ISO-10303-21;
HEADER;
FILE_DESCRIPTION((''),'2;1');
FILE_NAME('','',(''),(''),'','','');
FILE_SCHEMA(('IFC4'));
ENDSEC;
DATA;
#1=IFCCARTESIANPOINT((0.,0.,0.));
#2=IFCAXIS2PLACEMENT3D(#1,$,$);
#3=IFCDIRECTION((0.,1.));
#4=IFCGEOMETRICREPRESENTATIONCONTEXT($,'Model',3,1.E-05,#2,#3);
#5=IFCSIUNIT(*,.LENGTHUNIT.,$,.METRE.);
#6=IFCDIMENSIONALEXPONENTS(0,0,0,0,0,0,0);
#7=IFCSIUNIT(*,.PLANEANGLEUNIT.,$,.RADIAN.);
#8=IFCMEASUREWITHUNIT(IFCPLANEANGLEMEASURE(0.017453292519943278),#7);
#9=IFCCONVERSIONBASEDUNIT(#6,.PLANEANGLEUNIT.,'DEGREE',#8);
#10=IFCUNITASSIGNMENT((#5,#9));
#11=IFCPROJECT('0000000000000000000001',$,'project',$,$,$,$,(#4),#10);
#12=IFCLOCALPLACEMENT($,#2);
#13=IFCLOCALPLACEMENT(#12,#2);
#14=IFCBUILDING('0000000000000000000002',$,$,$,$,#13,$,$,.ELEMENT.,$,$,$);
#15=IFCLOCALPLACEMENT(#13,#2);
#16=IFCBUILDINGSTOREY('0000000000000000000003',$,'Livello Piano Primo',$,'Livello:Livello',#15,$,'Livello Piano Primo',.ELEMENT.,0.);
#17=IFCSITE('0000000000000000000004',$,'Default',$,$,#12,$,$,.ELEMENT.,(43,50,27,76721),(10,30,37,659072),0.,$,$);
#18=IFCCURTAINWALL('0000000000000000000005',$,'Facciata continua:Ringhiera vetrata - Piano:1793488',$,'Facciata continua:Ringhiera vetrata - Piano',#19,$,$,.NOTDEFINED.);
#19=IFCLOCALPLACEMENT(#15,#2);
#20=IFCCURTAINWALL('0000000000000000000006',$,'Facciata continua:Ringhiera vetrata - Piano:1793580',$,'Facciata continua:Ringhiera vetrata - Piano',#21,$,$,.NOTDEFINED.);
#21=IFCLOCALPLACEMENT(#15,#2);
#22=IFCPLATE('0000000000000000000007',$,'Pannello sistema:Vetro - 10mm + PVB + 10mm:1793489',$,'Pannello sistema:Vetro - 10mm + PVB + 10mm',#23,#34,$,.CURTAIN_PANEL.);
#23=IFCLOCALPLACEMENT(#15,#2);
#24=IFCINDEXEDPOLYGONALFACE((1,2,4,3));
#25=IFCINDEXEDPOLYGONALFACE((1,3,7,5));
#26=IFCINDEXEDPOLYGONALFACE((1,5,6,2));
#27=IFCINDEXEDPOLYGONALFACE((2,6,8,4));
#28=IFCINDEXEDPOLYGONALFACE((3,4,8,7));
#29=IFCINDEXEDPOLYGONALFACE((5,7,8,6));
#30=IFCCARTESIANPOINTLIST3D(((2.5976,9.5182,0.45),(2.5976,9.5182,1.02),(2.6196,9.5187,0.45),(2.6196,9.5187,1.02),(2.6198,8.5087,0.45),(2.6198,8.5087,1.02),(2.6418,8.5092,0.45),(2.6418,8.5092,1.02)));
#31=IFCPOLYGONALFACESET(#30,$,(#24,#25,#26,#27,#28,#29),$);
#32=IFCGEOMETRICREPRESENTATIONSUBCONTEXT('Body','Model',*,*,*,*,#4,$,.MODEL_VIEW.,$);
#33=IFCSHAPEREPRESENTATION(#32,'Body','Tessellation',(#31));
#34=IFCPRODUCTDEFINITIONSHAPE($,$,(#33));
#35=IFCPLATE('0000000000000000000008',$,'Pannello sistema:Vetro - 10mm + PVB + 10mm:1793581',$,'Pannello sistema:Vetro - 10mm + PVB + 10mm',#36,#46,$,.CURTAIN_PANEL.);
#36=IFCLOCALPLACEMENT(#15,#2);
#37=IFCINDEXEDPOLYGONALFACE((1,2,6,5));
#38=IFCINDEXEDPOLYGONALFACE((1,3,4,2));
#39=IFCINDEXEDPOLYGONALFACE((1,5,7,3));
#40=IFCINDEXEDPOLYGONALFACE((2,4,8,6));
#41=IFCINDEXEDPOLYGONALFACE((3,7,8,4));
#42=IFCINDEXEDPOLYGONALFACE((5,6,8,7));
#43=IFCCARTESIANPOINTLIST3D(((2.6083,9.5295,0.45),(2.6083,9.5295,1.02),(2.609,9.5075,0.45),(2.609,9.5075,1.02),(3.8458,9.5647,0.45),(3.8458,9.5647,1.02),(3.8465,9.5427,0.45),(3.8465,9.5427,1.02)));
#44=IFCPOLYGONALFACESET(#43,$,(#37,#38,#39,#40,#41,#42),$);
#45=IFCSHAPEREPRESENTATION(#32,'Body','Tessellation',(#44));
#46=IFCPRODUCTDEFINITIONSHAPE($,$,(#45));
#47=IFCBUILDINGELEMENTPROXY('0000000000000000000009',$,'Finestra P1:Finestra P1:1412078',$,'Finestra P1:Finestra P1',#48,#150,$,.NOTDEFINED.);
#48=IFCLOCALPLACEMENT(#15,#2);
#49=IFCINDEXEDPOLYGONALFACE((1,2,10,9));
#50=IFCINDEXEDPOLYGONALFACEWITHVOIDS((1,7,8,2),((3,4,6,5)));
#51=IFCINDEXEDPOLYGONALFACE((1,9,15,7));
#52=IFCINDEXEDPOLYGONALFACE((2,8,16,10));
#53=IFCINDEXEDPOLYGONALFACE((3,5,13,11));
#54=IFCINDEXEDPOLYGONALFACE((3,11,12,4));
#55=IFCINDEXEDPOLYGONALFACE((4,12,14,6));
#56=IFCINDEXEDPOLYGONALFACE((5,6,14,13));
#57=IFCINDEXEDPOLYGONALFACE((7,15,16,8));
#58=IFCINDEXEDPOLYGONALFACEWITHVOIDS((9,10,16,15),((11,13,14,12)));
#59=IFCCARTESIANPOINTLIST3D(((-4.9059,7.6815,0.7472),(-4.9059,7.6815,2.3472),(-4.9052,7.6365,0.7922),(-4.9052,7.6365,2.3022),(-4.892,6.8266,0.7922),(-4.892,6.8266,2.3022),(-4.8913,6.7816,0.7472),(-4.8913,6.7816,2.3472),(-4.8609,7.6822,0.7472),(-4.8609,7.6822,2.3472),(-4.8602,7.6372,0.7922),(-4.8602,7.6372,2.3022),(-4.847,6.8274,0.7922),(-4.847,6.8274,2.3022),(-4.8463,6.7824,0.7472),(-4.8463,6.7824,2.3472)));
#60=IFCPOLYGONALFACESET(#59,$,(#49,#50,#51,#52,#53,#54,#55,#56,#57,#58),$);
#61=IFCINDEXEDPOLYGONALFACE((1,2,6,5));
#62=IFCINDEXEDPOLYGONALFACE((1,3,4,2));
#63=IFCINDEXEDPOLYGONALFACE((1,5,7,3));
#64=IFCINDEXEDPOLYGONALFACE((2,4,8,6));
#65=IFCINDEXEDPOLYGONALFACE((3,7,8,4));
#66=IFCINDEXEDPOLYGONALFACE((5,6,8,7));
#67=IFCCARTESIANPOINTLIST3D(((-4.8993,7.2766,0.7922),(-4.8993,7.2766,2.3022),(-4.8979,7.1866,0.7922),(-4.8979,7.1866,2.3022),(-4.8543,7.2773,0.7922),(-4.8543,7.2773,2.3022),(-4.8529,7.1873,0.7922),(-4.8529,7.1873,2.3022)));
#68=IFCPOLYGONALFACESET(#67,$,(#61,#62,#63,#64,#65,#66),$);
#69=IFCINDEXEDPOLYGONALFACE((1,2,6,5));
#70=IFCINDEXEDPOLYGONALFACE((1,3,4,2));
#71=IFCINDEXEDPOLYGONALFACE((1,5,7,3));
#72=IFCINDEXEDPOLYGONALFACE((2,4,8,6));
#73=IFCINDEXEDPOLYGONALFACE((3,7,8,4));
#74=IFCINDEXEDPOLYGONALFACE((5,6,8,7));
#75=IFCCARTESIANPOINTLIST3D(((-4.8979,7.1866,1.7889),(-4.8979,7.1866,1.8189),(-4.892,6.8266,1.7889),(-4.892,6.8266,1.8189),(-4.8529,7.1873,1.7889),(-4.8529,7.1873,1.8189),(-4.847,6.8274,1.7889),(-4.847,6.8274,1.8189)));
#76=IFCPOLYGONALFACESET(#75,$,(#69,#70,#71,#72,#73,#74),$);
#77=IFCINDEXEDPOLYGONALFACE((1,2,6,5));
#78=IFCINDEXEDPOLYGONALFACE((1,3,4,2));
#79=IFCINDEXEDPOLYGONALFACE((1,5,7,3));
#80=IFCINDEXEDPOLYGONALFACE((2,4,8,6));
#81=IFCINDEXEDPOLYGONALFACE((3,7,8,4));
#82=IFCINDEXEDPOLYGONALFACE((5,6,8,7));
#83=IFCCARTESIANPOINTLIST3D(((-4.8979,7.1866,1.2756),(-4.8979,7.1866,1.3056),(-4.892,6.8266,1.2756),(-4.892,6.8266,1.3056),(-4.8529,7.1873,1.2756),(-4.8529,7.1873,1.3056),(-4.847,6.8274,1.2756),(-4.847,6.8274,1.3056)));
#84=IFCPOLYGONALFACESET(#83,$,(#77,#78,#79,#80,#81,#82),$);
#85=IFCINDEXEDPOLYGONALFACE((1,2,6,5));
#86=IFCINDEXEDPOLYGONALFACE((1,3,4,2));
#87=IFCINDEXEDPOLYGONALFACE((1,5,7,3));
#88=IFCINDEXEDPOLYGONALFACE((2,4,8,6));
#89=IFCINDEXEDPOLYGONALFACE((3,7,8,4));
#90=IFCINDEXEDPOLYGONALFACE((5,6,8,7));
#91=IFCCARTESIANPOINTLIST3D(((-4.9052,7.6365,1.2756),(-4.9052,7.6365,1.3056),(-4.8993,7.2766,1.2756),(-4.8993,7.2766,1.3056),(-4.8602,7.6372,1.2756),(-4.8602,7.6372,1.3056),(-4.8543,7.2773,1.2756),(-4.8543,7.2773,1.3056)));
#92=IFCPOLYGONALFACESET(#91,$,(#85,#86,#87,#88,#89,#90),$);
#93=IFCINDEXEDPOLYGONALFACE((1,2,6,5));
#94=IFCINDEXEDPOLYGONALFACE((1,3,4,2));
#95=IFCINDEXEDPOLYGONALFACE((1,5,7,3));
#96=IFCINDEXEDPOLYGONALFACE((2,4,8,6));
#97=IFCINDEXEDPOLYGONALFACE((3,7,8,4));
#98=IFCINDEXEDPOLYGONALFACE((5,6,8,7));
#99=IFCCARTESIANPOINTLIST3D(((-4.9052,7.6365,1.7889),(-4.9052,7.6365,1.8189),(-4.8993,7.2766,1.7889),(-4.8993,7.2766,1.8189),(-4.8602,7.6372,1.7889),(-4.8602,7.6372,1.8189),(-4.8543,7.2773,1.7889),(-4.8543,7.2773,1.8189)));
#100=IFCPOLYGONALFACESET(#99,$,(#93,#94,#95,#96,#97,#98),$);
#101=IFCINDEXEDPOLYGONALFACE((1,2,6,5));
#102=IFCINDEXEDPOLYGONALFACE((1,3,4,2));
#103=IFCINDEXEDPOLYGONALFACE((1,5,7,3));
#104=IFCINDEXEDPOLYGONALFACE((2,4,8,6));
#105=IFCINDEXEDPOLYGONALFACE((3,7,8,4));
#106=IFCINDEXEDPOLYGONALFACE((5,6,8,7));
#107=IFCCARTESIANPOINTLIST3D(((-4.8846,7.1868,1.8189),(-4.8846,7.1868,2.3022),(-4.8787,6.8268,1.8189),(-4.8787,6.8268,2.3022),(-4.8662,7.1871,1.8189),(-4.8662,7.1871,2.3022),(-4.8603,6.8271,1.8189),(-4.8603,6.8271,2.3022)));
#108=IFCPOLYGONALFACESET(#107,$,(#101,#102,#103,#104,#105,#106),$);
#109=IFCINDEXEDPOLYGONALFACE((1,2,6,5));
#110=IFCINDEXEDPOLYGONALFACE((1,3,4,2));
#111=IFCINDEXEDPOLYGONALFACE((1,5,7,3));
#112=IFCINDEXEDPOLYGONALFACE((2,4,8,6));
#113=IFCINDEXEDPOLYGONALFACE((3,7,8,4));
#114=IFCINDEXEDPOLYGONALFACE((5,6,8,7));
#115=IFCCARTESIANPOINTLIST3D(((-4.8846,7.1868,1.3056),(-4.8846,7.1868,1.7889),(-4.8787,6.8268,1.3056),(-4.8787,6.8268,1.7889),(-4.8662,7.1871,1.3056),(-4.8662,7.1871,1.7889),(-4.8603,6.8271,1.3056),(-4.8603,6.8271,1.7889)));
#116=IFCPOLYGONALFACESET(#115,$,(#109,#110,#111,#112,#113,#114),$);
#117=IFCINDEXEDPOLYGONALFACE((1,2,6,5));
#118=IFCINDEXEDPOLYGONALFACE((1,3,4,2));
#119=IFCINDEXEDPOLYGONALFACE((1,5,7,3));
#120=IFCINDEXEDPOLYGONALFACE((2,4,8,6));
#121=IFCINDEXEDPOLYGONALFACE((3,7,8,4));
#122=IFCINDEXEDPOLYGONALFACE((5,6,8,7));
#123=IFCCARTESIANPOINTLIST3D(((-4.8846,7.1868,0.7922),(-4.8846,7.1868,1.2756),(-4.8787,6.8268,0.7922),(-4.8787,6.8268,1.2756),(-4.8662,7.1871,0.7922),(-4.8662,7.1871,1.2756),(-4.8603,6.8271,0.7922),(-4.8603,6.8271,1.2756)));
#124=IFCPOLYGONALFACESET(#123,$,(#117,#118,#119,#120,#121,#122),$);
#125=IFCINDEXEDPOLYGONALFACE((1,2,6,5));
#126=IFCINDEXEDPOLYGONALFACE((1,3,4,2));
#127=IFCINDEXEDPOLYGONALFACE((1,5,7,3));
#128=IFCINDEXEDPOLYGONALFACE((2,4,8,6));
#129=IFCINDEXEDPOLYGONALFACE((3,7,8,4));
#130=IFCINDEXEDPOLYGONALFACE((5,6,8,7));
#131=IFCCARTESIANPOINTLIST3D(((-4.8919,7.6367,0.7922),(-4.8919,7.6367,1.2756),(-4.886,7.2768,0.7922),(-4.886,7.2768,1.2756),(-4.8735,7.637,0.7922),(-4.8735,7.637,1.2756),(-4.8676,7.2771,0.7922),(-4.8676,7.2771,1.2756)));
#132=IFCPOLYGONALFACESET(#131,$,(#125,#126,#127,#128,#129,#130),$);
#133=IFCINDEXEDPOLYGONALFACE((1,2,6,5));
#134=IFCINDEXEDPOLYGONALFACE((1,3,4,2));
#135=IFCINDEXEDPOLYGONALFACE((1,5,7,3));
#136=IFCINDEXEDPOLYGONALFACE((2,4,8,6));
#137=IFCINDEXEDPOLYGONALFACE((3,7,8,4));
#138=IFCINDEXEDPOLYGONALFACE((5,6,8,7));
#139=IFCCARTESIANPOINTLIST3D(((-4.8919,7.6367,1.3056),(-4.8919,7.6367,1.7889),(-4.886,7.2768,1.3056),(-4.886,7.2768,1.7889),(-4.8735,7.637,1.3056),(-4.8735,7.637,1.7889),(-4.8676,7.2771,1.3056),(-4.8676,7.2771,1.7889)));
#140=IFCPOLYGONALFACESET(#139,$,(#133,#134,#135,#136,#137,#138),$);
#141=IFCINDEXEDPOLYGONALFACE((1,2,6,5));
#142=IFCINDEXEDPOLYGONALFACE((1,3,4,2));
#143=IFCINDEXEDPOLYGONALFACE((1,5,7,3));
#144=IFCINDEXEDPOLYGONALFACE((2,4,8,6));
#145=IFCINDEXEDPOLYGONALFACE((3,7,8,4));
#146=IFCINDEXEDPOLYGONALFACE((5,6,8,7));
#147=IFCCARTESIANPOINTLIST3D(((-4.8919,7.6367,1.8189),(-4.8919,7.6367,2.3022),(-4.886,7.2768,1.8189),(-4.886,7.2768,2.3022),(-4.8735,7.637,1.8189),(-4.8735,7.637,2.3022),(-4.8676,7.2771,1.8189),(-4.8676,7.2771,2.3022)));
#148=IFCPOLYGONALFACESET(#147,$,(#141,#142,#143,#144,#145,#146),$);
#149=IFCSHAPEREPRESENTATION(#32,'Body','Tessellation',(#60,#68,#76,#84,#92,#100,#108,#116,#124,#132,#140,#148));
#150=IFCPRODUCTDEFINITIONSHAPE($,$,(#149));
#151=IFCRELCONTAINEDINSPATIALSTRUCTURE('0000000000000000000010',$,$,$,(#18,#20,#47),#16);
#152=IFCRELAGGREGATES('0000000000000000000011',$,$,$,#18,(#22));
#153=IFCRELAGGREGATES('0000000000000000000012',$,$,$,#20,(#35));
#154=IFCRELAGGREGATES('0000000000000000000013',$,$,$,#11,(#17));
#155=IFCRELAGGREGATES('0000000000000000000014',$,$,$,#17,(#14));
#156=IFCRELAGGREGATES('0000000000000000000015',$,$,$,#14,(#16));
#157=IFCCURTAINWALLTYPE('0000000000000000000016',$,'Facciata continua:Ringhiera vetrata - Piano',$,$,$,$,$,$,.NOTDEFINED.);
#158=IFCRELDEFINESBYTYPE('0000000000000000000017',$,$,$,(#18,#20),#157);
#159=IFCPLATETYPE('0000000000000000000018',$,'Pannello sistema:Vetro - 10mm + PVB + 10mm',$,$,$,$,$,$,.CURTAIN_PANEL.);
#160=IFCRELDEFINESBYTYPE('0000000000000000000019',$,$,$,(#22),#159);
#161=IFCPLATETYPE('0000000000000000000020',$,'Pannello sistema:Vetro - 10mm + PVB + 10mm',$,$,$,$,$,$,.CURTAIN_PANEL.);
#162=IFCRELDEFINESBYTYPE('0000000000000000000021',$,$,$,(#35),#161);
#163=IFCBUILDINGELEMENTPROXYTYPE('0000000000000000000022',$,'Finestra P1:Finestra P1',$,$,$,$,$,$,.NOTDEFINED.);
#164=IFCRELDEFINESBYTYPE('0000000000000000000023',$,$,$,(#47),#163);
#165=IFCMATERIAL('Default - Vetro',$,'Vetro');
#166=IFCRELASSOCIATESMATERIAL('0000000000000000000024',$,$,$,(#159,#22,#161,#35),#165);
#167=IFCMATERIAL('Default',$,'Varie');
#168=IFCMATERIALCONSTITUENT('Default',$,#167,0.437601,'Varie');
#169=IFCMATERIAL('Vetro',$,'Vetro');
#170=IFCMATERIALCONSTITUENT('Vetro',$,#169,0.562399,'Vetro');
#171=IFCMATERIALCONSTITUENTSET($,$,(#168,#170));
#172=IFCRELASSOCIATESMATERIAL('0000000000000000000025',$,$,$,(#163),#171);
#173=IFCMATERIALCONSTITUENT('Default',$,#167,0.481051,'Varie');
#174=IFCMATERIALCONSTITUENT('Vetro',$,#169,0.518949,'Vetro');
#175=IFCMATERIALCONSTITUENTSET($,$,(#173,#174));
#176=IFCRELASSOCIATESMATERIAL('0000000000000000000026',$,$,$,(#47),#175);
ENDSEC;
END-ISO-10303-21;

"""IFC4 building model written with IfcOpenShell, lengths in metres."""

from ifc_helpers import new_model, entity, si_unit, converted_unit, direction, frame, origin, place, context, subcontext, project, spatial, indexed_curve, outline, extrude, source, transform, mapped, material, constituent, constituent_set, type_object, type_shapes, element, aggregate, save


model = new_model("IFC4")

# Units and contexts
model_context = context("Model", 3, precision=1e-05, world=origin(), true_north=direction((0.0, 1.0)))
body_context = subcontext(model_context, "Body", "Model", "MODEL_VIEW")
ifc_project = project(units=[si_unit("LENGTHUNIT", "METRE"), converted_unit("PLANEANGLEUNIT", "DEGREE", entity("IfcPlaneAngleMeasure", 0.017453292519943278), si_unit("PLANEANGLEUNIT", "RADIAN"), dimensions=[0, 0, 0, 0, 0, 0, 0])], contexts=[model_context])

# Site, building, storey
site_placement = place(None, origin())
site = spatial("IfcSite", under=ifc_project, at=site_placement, Name="Default", CompositionType="ELEMENT", RefLatitude=(43, 50, 27, 76721), RefLongitude=(10, 30, 37, 659072), RefElevation=0.0)
building_placement = place(site_placement, origin())
building = spatial("IfcBuilding", under=site, at=building_placement, CompositionType="ELEMENT")
storey_placement = place(building_placement, origin())
storey = spatial("IfcBuildingStorey", under=building, at=storey_placement, Name="Livello Piano Primo", ObjectType="Livello:Livello", LongName="Livello Piano Primo", CompositionType="ELEMENT", Elevation=0.0)

# Curtain walls
curtain_wall_type = type_object("IfcCurtainWallType", Name="Facciata continua:Ringhiera vetrata - Piano", PredefinedType="NOTDEFINED")
curtain_wall_1_placement = place(storey_placement, origin())
curtain_wall_1 = element("IfcCurtainWall", 1, at=curtain_wall_1_placement, inside=storey, type_object=curtain_wall_type, Name="Facciata continua:Ringhiera vetrata - Piano:1793488", ObjectType="Facciata continua:Ringhiera vetrata - Piano", PredefinedType="NOTDEFINED")
curtain_wall_2_placement = place(storey_placement, origin())
curtain_wall_2 = element("IfcCurtainWall", 2, at=curtain_wall_2_placement, inside=storey, type_object=curtain_wall_type, Name="Facciata continua:Ringhiera vetrata - Piano:1793580", ObjectType="Facciata continua:Ringhiera vetrata - Piano", PredefinedType="NOTDEFINED")

# Plates
ifc_material_1 = material(Name="Default - Vetro", Category="Vetro")
plate_type_1 = type_object("IfcPlateType", Name="Pannello sistema:Vetro - 10mm + PVB + 10mm", PredefinedType="CURTAIN_PANEL", material=ifc_material_1)
shared_shape_1 = source(origin(), body_context, "Body", "SweptSolid", [
    extrude(outline(indexed_curve([(-0.011, -0.5049), (0.011, -0.5049), (0.011, 0.5049), (-0.011, 0.5049), (-0.011, -0.5049)], self_intersect=False)), frame((0.0, 0.0, 0.0), z_axis=(0.0, 0.0, 1.0), x_axis=(0.0, 1.0, 0.0)), (0.0, 0.0, 1.0), 0.57),
])
type_shapes(plate_type_1, [shared_shape_1])
plate_1_placement = place(curtain_wall_1_placement, frame((2.6197, 9.0137, 0.45), z_axis=(0.0, 0.0, 1.0), x_axis=(-0.021989, 0.999758, 0.0)))
plate_1 = element("IfcPlate", 3, at=plate_1_placement, type_object=plate_type_1, material=ifc_material_1, Name="Pannello sistema:Vetro - 10mm + PVB + 10mm:1793489", ObjectType="Pannello sistema:Vetro - 10mm + PVB + 10mm", PredefinedType="CURTAIN_PANEL", context=body_context, shape_type="MappedRepresentation", body=[
    mapped(shared_shape_1, transform((0.0, 0.0, 0.0), scale=1.0)),
])
aggregate(curtain_wall_1, [plate_1])
plate_type_2 = type_object("IfcPlateType", Name="Pannello sistema:Vetro - 10mm + PVB + 10mm", PredefinedType="CURTAIN_PANEL", material=ifc_material_1)
shared_shape_2 = source(origin(), body_context, "Body", "SweptSolid", [
    extrude(outline(indexed_curve([(-0.011, -0.619), (0.011, -0.619), (0.011, 0.619), (-0.011, 0.619), (-0.011, -0.619)], self_intersect=False)), frame((0.0, 0.0, 0.0), z_axis=(0.0, 0.0, 1.0), x_axis=(0.0, 1.0, 0.0)), (0.0, 0.0, 1.0), 0.57),
])
type_shapes(plate_type_2, [shared_shape_2])
plate_2_placement = place(curtain_wall_2_placement, frame((3.2274, 9.5361, 0.45), z_axis=(0.0, 0.0, 1.0), x_axis=(0.999596, 0.028429, 0.0)))
plate_2 = element("IfcPlate", 4, at=plate_2_placement, type_object=plate_type_2, material=ifc_material_1, Name="Pannello sistema:Vetro - 10mm + PVB + 10mm:1793581", ObjectType="Pannello sistema:Vetro - 10mm + PVB + 10mm", PredefinedType="CURTAIN_PANEL", context=body_context, shape_type="MappedRepresentation", body=[
    mapped(shared_shape_2, transform((0.0, 0.0, 0.0), scale=1.0)),
])
aggregate(curtain_wall_2, [plate_2])

# Building element proxy
ifc_material_2 = material(Name="Default", Category="Varie")
ifc_constituent_1 = constituent(ifc_material_2, Name="Default", Category="Varie", fraction=0.481051)
ifc_material_3 = material(Name="Vetro", Category="Vetro")
ifc_constituent_2 = constituent(ifc_material_3, Name="Vetro", Category="Vetro", fraction=0.518949)
ifc_constituent_set_1 = constituent_set(constituents=[ifc_constituent_1, ifc_constituent_2])
ifc_constituent_3 = constituent(ifc_material_2, Name="Default", Category="Varie", fraction=0.437601)
ifc_constituent_4 = constituent(ifc_material_3, Name="Vetro", Category="Vetro", fraction=0.562399)
ifc_constituent_set_2 = constituent_set(constituents=[ifc_constituent_3, ifc_constituent_4])
building_element_proxy_type_1 = type_object("IfcBuildingElementProxyType", Name="Finestra P1:Finestra P1", PredefinedType="NOTDEFINED", material=ifc_constituent_set_2)
shared_shape_3 = source(origin(), body_context, "Body", "SweptSolid", [
    extrude(outline(indexed_curve([(-0.8, -0.45), (0.8, -0.45), (0.8, 0.45), (-0.8, 0.45), (-0.8, -0.45)], self_intersect=False), holes=[indexed_curve([(0.755, -0.405), (-0.755, -0.405), (-0.755, 0.405), (0.755, 0.405), (0.755, -0.405)], self_intersect=False)]), frame((0.0, -0.0225, 0.8), z_axis=(0.0, 1.0, 0.0), x_axis=(0.0, 0.0, -1.0)), (0.0, 0.0, 1.0), 0.045),
    extrude(outline(indexed_curve([(-0.045, -0.0225), (0.045, -0.0225), (0.045, 0.0225), (-0.045, 0.0225), (-0.045, -0.0225)], self_intersect=False)), frame((0.0, 0.0, 0.045), z_axis=(0.0, 0.0, 1.0), x_axis=(-1.0, 0.0, 0.0)), (0.0, 0.0, 1.0), 1.51),
    extrude(outline(indexed_curve([(-0.18, -0.0225), (0.18, -0.0225), (0.18, 0.0225), (-0.18, 0.0225), (-0.18, -0.0225)], self_intersect=False)), frame((0.225, 0.0, 1.0417)), (0.0, 0.0, 1.0), 0.03),
    extrude(outline(indexed_curve([(-0.18, -0.0225), (0.18, -0.0225), (0.18, 0.0225), (-0.18, 0.0225), (-0.18, -0.0225)], self_intersect=False)), frame((0.225, 0.0, 0.5283)), (0.0, 0.0, 1.0), 0.03),
    extrude(outline(indexed_curve([(-0.18, -0.0225), (0.18, -0.0225), (0.18, 0.0225), (-0.18, 0.0225), (-0.18, -0.0225)], self_intersect=False)), frame((-0.225, 0.0, 0.5283)), (0.0, 0.0, 1.0), 0.03),
    extrude(outline(indexed_curve([(-0.18, -0.0225), (0.18, -0.0225), (0.18, 0.0225), (-0.18, 0.0225), (-0.18, -0.0225)], self_intersect=False)), frame((-0.225, 0.0, 1.0417)), (0.0, 0.0, 1.0), 0.03),
    extrude(outline(indexed_curve([(-0.18, -0.0092), (0.18, -0.0092), (0.18, 0.0092), (-0.18, 0.0092), (-0.18, -0.0092)], self_intersect=False)), frame((0.225, 0.0, 1.0717), z_axis=(0.0, 0.0, 1.0), x_axis=(-1.0, 0.0, 0.0)), (0.0, 0.0, 1.0), 0.4833),
    extrude(outline(indexed_curve([(-0.18, -0.0092), (0.18, -0.0092), (0.18, 0.0092), (-0.18, 0.0092), (-0.18, -0.0092)], self_intersect=False)), frame((0.225, 0.0, 0.5583), z_axis=(0.0, 0.0, 1.0), x_axis=(-1.0, 0.0, 0.0)), (0.0, 0.0, 1.0), 0.4833),
    extrude(outline(indexed_curve([(-0.18, -0.0092), (0.18, -0.0092), (0.18, 0.0092), (-0.18, 0.0092), (-0.18, -0.0092)], self_intersect=False)), frame((0.225, 0.0, 0.045), z_axis=(0.0, 0.0, 1.0), x_axis=(-1.0, 0.0, 0.0)), (0.0, 0.0, 1.0), 0.4833),
    extrude(outline(indexed_curve([(-0.18, -0.0092), (0.18, -0.0092), (0.18, 0.0092), (-0.18, 0.0092), (-0.18, -0.0092)], self_intersect=False)), frame((-0.225, 0.0, 0.045), z_axis=(0.0, 0.0, 1.0), x_axis=(-1.0, 0.0, 0.0)), (0.0, 0.0, 1.0), 0.4833),
    extrude(outline(indexed_curve([(-0.18, -0.0092), (0.18, -0.0092), (0.18, 0.0092), (-0.18, 0.0092), (-0.18, -0.0092)], self_intersect=False)), frame((-0.225, 0.0, 0.5583), z_axis=(0.0, 0.0, 1.0), x_axis=(-1.0, 0.0, 0.0)), (0.0, 0.0, 1.0), 0.4833),
    extrude(outline(indexed_curve([(-0.18, -0.0092), (0.18, -0.0092), (0.18, 0.0092), (-0.18, 0.0092), (-0.18, -0.0092)], self_intersect=False)), frame((-0.225, 0.0, 1.0717), z_axis=(0.0, 0.0, 1.0), x_axis=(-1.0, 0.0, 0.0)), (0.0, 0.0, 1.0), 0.4833),
])
type_shapes(building_element_proxy_type_1, [shared_shape_3])
proxy_1_placement = place(storey_placement, frame((-4.8761, 7.2319, 0.7472), z_axis=(0.0, 0.0, 1.0), x_axis=(0.016204, -0.999869, 0.0)))
element("IfcBuildingElementProxy", 5, at=proxy_1_placement, inside=storey, type_object=building_element_proxy_type_1, material=ifc_constituent_set_1, Name="Finestra P1:Finestra P1:1412078", ObjectType="Finestra P1:Finestra P1", PredefinedType="NOTDEFINED", context=body_context, shape_type="MappedRepresentation", body=[
    mapped(shared_shape_3, transform((0.0, 0.0, 0.0), scale=1.0)),
])

save(model, "model.ifc")
